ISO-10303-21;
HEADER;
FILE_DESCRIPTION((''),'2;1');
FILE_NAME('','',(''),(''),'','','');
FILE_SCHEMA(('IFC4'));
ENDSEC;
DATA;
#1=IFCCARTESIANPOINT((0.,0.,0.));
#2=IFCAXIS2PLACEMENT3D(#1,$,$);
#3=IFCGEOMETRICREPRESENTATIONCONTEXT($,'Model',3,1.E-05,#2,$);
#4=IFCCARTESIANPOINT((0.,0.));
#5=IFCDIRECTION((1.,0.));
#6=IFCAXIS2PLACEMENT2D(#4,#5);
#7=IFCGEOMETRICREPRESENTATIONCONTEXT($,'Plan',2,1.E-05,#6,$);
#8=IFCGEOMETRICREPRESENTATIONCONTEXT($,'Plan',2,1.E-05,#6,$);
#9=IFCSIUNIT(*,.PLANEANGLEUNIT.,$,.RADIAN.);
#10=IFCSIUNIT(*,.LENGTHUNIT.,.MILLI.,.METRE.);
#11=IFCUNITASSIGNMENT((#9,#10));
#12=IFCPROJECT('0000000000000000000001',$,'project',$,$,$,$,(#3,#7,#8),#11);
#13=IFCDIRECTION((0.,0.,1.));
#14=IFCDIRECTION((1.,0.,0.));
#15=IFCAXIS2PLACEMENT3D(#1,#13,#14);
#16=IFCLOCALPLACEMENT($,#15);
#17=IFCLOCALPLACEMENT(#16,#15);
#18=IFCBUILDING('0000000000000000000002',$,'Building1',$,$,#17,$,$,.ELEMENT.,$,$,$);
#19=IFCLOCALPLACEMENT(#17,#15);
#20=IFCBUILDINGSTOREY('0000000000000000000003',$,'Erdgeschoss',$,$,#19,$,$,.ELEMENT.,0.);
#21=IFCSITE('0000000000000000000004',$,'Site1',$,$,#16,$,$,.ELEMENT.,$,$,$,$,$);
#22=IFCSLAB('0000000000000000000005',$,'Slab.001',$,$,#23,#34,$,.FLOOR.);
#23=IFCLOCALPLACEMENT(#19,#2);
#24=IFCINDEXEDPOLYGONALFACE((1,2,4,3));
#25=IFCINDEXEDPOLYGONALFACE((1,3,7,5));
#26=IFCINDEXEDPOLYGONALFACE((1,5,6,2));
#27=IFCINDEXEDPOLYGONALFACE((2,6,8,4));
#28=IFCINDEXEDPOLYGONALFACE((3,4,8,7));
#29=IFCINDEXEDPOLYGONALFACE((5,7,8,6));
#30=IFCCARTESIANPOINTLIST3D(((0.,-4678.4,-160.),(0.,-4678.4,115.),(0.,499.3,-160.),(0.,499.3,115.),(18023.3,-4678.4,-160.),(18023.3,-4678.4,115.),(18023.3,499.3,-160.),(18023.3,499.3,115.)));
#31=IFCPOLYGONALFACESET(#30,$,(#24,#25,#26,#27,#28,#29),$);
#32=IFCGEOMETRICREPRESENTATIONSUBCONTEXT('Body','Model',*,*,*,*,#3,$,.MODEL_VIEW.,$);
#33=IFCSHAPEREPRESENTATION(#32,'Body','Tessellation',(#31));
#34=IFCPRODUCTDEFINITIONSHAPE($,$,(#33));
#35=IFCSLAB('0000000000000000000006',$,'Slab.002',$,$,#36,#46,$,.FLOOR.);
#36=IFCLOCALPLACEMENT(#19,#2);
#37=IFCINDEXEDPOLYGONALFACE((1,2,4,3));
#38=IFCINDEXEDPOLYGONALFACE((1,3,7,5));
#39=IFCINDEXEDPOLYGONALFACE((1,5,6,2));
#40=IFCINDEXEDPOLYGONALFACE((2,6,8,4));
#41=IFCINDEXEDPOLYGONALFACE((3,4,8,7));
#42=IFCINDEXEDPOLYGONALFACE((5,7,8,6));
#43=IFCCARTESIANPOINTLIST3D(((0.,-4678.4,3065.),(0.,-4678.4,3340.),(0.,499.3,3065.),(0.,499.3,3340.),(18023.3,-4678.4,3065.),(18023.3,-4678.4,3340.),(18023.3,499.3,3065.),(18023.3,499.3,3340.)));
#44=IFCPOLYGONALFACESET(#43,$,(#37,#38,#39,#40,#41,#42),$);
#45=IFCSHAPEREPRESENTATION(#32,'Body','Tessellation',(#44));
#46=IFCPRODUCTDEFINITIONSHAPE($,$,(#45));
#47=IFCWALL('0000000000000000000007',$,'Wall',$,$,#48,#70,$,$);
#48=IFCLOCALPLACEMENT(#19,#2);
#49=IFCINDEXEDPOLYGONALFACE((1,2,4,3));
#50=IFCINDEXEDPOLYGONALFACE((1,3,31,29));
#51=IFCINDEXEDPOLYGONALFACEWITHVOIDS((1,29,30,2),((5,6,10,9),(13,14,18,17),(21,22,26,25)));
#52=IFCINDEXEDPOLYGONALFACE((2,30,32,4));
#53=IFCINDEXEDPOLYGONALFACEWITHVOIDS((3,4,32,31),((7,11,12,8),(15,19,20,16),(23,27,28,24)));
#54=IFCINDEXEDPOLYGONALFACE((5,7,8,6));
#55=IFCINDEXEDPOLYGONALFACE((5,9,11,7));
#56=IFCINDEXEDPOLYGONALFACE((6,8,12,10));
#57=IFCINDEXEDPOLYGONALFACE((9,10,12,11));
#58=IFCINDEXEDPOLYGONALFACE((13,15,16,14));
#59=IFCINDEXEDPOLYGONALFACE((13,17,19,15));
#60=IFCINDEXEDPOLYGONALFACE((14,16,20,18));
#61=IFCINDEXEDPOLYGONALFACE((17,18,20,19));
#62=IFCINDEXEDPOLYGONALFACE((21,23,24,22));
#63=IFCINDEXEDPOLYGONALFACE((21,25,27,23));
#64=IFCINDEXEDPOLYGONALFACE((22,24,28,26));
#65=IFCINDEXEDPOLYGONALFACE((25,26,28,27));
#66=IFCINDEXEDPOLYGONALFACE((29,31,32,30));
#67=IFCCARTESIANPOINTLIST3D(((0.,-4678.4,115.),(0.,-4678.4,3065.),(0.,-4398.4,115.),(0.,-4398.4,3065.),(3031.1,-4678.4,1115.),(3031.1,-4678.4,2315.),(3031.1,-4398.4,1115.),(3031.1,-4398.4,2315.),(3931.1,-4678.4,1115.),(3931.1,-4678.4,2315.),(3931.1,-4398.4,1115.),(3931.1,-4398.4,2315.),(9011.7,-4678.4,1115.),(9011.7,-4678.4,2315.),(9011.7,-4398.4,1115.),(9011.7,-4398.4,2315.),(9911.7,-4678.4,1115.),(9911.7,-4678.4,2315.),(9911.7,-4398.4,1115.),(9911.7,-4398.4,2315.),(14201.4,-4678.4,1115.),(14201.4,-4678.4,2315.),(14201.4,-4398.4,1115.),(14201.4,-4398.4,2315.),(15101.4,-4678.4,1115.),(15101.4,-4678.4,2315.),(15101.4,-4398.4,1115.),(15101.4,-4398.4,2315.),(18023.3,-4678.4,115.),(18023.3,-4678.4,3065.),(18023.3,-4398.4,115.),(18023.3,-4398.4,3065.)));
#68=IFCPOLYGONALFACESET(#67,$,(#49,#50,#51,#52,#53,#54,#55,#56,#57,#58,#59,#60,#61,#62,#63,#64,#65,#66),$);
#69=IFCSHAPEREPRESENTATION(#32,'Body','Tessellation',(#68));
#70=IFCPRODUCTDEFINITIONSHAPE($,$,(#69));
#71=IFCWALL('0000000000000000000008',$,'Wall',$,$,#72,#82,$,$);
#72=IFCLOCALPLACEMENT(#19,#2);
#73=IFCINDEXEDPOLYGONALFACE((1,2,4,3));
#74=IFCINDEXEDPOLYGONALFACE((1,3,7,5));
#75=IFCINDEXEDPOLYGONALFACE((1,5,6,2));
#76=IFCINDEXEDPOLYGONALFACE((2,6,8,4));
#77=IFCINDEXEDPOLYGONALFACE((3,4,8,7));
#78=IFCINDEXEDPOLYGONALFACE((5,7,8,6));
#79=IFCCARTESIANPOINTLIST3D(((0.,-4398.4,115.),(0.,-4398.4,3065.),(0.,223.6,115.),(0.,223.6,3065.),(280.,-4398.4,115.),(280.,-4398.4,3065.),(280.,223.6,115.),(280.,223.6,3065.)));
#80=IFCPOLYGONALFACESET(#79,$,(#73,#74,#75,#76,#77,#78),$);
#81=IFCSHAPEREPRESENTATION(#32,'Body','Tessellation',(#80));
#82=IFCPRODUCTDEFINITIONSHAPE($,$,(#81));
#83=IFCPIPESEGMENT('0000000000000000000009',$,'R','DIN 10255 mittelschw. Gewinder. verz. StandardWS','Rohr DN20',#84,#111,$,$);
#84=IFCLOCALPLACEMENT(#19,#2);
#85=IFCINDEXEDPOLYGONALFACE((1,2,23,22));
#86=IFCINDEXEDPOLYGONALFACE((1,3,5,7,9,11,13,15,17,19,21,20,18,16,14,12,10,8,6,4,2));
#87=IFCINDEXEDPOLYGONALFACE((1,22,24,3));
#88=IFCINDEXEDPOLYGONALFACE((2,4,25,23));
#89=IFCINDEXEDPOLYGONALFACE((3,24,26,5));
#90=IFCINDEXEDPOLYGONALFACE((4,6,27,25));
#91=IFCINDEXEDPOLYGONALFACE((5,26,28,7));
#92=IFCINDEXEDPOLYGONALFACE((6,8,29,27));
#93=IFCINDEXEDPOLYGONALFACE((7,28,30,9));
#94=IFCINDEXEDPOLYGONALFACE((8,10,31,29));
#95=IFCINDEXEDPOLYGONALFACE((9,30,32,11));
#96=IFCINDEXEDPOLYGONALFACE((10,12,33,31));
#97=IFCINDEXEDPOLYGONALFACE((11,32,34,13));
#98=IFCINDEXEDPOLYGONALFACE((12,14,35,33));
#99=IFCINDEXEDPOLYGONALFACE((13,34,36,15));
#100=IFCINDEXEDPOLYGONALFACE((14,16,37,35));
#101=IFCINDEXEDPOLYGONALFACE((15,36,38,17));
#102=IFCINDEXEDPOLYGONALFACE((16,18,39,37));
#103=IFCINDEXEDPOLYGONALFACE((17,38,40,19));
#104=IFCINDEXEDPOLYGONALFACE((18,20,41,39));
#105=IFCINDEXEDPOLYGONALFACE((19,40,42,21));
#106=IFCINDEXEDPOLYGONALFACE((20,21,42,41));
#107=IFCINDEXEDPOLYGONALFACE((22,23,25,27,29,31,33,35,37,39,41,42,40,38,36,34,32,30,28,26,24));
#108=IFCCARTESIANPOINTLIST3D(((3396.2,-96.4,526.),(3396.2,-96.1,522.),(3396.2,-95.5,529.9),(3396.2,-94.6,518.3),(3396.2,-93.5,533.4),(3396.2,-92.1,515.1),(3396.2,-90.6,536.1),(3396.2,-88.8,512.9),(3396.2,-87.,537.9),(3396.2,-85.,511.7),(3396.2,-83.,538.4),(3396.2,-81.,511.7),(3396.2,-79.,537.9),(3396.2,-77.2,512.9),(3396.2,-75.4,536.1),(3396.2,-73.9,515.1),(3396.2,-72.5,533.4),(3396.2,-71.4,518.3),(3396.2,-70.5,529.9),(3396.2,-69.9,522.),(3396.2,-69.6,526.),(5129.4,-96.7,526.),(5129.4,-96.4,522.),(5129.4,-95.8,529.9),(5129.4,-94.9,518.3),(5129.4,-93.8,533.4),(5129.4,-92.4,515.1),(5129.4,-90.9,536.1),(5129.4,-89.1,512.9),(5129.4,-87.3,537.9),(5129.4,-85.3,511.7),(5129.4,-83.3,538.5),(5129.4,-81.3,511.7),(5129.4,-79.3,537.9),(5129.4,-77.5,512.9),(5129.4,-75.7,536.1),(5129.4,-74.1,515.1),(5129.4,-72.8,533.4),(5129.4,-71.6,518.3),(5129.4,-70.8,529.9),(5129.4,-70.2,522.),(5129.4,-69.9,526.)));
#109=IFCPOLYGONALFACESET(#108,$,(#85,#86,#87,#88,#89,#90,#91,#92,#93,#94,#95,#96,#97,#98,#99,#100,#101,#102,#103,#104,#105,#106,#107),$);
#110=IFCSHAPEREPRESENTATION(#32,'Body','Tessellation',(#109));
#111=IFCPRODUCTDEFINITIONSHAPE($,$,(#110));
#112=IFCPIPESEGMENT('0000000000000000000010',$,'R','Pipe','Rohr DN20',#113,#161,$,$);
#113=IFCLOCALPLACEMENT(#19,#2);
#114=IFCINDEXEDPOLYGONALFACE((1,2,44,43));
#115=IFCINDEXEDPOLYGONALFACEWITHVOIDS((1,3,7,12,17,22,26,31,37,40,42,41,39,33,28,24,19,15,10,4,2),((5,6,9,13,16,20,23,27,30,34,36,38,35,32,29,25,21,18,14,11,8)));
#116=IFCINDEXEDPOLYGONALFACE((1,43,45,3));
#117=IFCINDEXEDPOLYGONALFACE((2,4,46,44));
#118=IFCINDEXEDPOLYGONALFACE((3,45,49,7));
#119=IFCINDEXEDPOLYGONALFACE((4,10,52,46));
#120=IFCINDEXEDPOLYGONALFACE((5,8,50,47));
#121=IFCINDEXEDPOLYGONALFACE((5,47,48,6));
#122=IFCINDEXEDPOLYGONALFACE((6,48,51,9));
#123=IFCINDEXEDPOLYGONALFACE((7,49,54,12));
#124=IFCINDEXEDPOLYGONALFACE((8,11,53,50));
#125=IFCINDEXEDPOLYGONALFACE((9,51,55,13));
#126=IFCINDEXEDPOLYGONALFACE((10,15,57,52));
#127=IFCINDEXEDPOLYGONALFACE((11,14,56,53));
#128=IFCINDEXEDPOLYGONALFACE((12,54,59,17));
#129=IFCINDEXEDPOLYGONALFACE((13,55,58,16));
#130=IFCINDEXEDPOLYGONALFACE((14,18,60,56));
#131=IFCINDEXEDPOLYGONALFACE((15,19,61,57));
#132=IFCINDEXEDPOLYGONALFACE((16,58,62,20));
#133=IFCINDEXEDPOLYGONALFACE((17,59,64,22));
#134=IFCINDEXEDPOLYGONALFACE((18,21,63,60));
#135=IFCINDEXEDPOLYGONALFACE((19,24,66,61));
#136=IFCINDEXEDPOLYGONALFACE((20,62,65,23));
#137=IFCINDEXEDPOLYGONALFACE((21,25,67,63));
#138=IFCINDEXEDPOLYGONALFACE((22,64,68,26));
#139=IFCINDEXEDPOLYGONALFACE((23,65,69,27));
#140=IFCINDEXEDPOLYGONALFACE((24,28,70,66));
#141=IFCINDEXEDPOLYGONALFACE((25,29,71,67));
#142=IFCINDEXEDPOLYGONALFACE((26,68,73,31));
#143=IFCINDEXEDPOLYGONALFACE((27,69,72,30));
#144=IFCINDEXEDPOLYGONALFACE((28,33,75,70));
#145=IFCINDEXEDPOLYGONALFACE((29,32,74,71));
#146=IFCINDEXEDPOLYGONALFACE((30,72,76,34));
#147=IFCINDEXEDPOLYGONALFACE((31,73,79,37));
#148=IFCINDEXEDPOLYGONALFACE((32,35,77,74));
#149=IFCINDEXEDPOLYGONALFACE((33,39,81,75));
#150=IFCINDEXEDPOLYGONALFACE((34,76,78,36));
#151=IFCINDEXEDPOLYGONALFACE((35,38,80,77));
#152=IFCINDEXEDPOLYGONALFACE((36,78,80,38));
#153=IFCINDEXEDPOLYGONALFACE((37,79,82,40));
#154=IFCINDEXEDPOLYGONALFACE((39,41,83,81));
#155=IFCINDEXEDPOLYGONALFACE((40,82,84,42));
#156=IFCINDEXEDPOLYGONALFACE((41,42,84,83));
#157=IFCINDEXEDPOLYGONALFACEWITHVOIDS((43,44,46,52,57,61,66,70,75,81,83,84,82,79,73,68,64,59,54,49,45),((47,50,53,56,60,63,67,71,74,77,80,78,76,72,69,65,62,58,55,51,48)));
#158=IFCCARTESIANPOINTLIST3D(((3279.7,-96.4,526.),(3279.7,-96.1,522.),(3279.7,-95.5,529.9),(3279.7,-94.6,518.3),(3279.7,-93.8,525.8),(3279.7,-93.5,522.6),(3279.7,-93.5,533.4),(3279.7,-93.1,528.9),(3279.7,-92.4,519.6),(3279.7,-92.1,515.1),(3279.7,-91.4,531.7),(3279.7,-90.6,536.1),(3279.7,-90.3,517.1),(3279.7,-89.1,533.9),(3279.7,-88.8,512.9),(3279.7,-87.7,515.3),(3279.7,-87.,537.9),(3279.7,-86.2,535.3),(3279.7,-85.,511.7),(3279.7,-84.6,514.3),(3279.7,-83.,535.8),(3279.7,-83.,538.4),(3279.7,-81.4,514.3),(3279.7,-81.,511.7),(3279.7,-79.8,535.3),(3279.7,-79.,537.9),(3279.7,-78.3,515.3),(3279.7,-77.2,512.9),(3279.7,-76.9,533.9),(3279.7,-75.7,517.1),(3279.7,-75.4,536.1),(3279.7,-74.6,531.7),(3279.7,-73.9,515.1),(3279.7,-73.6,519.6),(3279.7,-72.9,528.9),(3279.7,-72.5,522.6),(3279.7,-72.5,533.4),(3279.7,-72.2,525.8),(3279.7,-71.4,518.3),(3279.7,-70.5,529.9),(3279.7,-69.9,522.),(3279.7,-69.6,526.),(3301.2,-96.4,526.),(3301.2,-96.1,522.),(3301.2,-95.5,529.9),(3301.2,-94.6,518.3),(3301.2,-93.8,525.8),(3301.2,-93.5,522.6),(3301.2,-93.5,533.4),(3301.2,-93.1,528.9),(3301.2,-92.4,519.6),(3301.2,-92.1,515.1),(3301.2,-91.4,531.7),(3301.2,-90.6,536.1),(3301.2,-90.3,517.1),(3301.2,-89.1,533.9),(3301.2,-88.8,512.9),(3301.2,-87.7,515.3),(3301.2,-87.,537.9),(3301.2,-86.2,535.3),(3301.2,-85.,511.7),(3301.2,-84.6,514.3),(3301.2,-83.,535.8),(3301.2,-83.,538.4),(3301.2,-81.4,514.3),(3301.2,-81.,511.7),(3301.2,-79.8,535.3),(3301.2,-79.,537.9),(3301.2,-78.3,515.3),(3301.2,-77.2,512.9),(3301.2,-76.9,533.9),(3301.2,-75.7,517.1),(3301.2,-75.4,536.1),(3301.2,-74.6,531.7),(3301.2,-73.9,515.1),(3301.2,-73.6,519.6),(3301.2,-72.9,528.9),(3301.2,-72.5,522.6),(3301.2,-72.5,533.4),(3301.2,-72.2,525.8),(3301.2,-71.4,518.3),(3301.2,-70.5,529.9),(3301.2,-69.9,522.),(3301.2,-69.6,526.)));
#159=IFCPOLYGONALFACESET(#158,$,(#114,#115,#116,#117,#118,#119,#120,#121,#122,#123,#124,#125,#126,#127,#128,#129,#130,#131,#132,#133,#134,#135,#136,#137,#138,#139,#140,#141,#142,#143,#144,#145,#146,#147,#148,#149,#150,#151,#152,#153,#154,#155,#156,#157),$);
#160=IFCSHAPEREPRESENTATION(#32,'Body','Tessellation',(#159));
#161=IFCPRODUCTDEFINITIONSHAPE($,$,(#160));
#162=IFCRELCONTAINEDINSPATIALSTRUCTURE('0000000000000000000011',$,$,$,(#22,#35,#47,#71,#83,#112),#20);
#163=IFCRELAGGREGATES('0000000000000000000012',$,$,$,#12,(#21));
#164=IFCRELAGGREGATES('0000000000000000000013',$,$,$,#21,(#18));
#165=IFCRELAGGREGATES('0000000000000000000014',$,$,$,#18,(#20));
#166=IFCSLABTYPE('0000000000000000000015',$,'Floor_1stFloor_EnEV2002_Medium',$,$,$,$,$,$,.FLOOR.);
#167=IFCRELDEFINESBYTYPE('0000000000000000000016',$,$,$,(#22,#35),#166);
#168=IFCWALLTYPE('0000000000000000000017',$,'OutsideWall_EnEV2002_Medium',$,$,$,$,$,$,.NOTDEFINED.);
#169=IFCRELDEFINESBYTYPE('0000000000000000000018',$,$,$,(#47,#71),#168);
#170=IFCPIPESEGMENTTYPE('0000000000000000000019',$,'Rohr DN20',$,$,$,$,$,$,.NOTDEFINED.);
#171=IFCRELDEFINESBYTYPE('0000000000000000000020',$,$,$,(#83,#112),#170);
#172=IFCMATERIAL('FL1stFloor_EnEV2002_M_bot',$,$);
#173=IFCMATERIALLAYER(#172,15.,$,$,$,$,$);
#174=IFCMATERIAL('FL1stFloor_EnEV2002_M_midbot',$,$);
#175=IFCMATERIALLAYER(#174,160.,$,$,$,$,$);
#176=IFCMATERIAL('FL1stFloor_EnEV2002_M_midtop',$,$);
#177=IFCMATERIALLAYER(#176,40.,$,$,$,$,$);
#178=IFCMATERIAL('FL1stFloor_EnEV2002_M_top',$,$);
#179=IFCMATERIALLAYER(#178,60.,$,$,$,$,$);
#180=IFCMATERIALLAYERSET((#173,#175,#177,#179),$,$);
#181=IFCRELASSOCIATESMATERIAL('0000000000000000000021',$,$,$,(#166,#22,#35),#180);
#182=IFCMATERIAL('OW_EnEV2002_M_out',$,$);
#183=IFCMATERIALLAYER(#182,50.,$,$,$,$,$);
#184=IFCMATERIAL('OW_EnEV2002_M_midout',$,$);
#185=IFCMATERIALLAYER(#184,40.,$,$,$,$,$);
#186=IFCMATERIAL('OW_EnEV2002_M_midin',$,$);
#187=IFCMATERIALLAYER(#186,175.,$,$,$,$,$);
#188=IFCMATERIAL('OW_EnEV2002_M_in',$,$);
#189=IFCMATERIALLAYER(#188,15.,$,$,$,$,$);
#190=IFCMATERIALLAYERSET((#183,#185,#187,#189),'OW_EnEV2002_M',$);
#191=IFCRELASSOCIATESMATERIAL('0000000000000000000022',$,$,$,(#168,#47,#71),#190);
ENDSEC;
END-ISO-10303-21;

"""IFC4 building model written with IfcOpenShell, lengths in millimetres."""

from ifc_helpers import new_model, si_unit, frame, origin, origin_with_axes, origin_2d_with_axis, place, context, subcontext, project, spatial, line, indexed_curve, circle, hollow_circle, outline, extrude, source, transform, mapped, material, layer, layer_set, layer_usage, type_object, element, save


model = new_model("IFC4")

# Units and contexts
model_context = context("Model", 3, precision=1e-05, world=origin())
plan_context_1 = context("Plan", 2, precision=1e-05, world=origin_2d_with_axis())
plan_context_2 = context("Plan", 2, precision=1e-05, world=origin_2d_with_axis())
body_context = subcontext(model_context, "Body", "Model", "MODEL_VIEW")
ifc_project = project(units=[si_unit("PLANEANGLEUNIT", "RADIAN"), si_unit("LENGTHUNIT", "METRE", prefix="MILLI")], contexts=[model_context, plan_context_1, plan_context_2])

# Site, building, storey
site_placement = place(None, origin_with_axes())
site = spatial("IfcSite", under=ifc_project, at=site_placement, Name="Site1", CompositionType="ELEMENT")
building_placement = place(site_placement, origin_with_axes())
building = spatial("IfcBuilding", under=site, at=building_placement, Name="Building1", CompositionType="ELEMENT")
storey_placement = place(building_placement, origin_with_axes())
storey = spatial("IfcBuildingStorey", under=building, at=storey_placement, Name="Erdgeschoss", CompositionType="ELEMENT", Elevation=0.0)

# Slabs
ifc_material_1 = material(Name="FL1stFloor_EnEV2002_M_bot")
ifc_layer_1 = layer(ifc_material_1, 15.0)
ifc_material_2 = material(Name="FL1stFloor_EnEV2002_M_midbot")
ifc_layer_2 = layer(ifc_material_2, 160.0)
ifc_material_3 = material(Name="FL1stFloor_EnEV2002_M_midtop")
ifc_layer_3 = layer(ifc_material_3, 40.0)
ifc_material_4 = material(Name="FL1stFloor_EnEV2002_M_top")
ifc_layer_4 = layer(ifc_material_4, 60.0)
ifc_layer_set_1 = layer_set([ifc_layer_1, ifc_layer_2, ifc_layer_3, ifc_layer_4])
ifc_layer_usage_1 = layer_usage(ifc_layer_set_1, "AXIS3", "POSITIVE", 0.0)
slab_type = type_object("IfcSlabType", Name="Floor_1stFloor_EnEV2002_Medium", PredefinedType="FLOOR", material=ifc_layer_set_1)
slab_1_placement = place(storey_placement, frame((0.0, -4678.4, -160.0), z_axis=(0.0, 0.0, 1.0), x_axis=(1.0, 0.0, 0.0)))
element("IfcSlab", 1, at=slab_1_placement, inside=storey, type_object=slab_type, material=ifc_layer_usage_1, Name="Slab.001", PredefinedType="FLOOR", context=body_context, shape_type="SweptSolid", body=[
    extrude(outline(indexed_curve([(0.0, 0.0), (18023.3, 0.0), (18023.3, 5177.6), (0.0, 5177.6)], segments=[line(3, 2), line(2, 1), line(1, 4), line(4, 3)], self_intersect=False)), None, (0.0, 0.0, 1.0), 275.0),
])
ifc_layer_usage_2 = layer_usage(ifc_layer_set_1, "AXIS3", "POSITIVE", 0.0)
slab_2_placement = place(storey_placement, frame((0.0, -4678.4, 3065.0), z_axis=(0.0, 0.0, 1.0), x_axis=(1.0, 0.0, 0.0)))
element("IfcSlab", 2, at=slab_2_placement, inside=storey, type_object=slab_type, material=ifc_layer_usage_2, Name="Slab.002", PredefinedType="FLOOR", context=body_context, shape_type="SweptSolid", body=[
    extrude(outline(indexed_curve([(0.0, 0.0), (18023.3, 0.0), (18023.3, 5177.6), (0.0, 5177.6)], segments=[line(3, 2), line(2, 1), line(1, 4), line(4, 3)], self_intersect=False)), None, (0.0, 0.0, 1.0), 275.0),
])

# Wall, openings
ifc_material_5 = material(Name="OW_EnEV2002_M_out")
ifc_layer_5 = layer(ifc_material_5, 50.0)
ifc_material_6 = material(Name="OW_EnEV2002_M_midout")
ifc_layer_6 = layer(ifc_material_6, 40.0)
ifc_material_7 = material(Name="OW_EnEV2002_M_midin")
ifc_layer_7 = layer(ifc_material_7, 175.0)
ifc_material_8 = material(Name="OW_EnEV2002_M_in")
ifc_layer_8 = layer(ifc_material_8, 15.0)
ifc_layer_set_2 = layer_set([ifc_layer_5, ifc_layer_6, ifc_layer_7, ifc_layer_8], Name="OW_EnEV2002_M")
ifc_layer_usage_3 = layer_usage(ifc_layer_set_2, "AXIS2", "POSITIVE", 0.0)
wall_type = type_object("IfcWallType", Name="OutsideWall_EnEV2002_Medium", PredefinedType="NOTDEFINED", material=ifc_layer_set_2)
wall_1_placement = place(storey_placement, frame((0.0, -4678.4, 115.0), z_axis=(0.0, 0.0, 1.0), x_axis=(1.0, 0.0, 0.0)))
wall_1 = element("IfcWall", 3, at=wall_1_placement, inside=storey, type_object=wall_type, material=ifc_layer_usage_3, Name="Wall", context=body_context, shape_type="SweptSolid", body=[
    extrude(outline(indexed_curve([(0.0, 0.0), (0.0, 280.0), (18023.3, 280.0), (18023.3, 0.0), (0.0, 0.0)], self_intersect=False)), origin_with_axes(), (0.0, 0.0, 1.0), 2950.0),
])
shared_shape_1 = source(origin_with_axes(), body_context, "Body", "SweptSolid", [
    extrude(outline(indexed_curve([(0.0, 0.0), (900.0, 0.0), (900.0, 1200.0), (0.0, 1200.0)], segments=[line(1, 2, 3, 4, 1)])), frame((0.0, -600.0, 0.0), z_axis=(0.0, -1.0, 0.0), x_axis=(1.0, 0.0, 0.0)), (0.0, 0.0, -1.0), 1200.0),
])
opening_1_placement = place(wall_1_placement, frame((9011.7, 0.0, 1000.0), z_axis=(0.0, 0.0, 1.0), x_axis=(1.0, 0.0, 0.0)))
element("IfcOpeningElement", 4, at=opening_1_placement, cuts=wall_1, PredefinedType="OPENING", context=body_context, shape_type="MappedRepresentation", body=[
    mapped(shared_shape_1, transform((0.0, 0.0, 0.0), x_axis=(1.0, 0.0, 0.0), y_axis=(0.0, 1.0, 0.0), z_axis=(0.0, 0.0, 1.0), scale=1.0)),
])
opening_2_placement = place(wall_1_placement, frame((3031.1, 0.0, 1000.0), z_axis=(0.0, 0.0, 1.0), x_axis=(1.0, 0.0, 0.0)))
element("IfcOpeningElement", 5, at=opening_2_placement, cuts=wall_1, PredefinedType="OPENING", context=body_context, shape_type="MappedRepresentation", body=[
    mapped(shared_shape_1, transform((0.0, 0.0, 0.0), x_axis=(1.0, 0.0, 0.0), y_axis=(0.0, 1.0, 0.0), z_axis=(0.0, 0.0, 1.0), scale=1.0)),
])
opening_3_placement = place(wall_1_placement, frame((14201.4, 0.0, 1000.0), z_axis=(0.0, 0.0, 1.0), x_axis=(1.0, 0.0, 0.0)))
element("IfcOpeningElement", 6, at=opening_3_placement, cuts=wall_1, PredefinedType="OPENING", context=body_context, shape_type="MappedRepresentation", body=[
    mapped(shared_shape_1, transform((0.0, 0.0, 0.0), x_axis=(1.0, 0.0, 0.0), y_axis=(0.0, 1.0, 0.0), z_axis=(0.0, 0.0, 1.0), scale=1.0)),
])

# Wall
ifc_layer_usage_4 = layer_usage(ifc_layer_set_2, "AXIS2", "POSITIVE", 0.0)
wall_2_placement = place(storey_placement, frame((280.0, -4398.4, 115.0), z_axis=(0.0, 0.0, 1.0), x_axis=(0.0, 1.0, 0.0)))
element("IfcWall", 7, at=wall_2_placement, inside=storey, type_object=wall_type, material=ifc_layer_usage_4, Name="Wall", context=body_context, shape_type="SweptSolid", body=[
    extrude(outline(indexed_curve([(0.0, 0.0), (0.0, 280.0), (4622.0, 280.0), (4622.0, 0.0), (0.0, 0.0)], self_intersect=False)), origin_with_axes(), (0.0, 0.0, 1.0), 2950.0),
])

# Pipe segments
pipe_segment_type_1 = type_object("IfcPipeSegmentType", Name="Rohr DN20", PredefinedType="NOTDEFINED")
pipe_segment_1_placement = place(storey_placement, frame((4262.8, -83.3, 525.0), z_axis=(0.0, 0.0, 1.0), x_axis=(1.0, 0.0, 0.0)))
element("IfcPipeSegment", 8, at=pipe_segment_1_placement, inside=storey, type_object=pipe_segment_type_1, Name="R", Description="DIN 10255 mittelschw. Gewinder. verz. StandardWS", ObjectType="Rohr DN20", context=body_context, shape_type="SolidModel", body=[
    extrude(circle(Radius=13.4, at=origin_2d_with_axis()), frame((866.6, 0.0, 0.0), z_axis=(-1.0, 0.000169, -0.000005), x_axis=(0.0, 0.0, 1.0)), (0.0, 0.0, 1.0), 1733.1),
])
pipe_segment_2_placement = place(storey_placement, frame((3290.5, -82.8, 525.0), z_axis=(0.0, 0.0, 1.0), x_axis=(1.0, 0.0, 0.0)))
element("IfcPipeSegment", 9, at=pipe_segment_2_placement, inside=storey, type_object=pipe_segment_type_1, Name="R", Description="Pipe", ObjectType="Rohr DN20", context=body_context, shape_type="SolidModel", body=[
    extrude(hollow_circle(Radius=13.4, WallThickness=2.6, at=origin_2d_with_axis()), frame((-10.8, -0.1, 0.0), z_axis=(1.0, 0.0, 0.000043), x_axis=(0.0, 0.0, 1.0)), (0.0, 0.0, 1.0), 21.5),
])

save(model, "model.ifc")
